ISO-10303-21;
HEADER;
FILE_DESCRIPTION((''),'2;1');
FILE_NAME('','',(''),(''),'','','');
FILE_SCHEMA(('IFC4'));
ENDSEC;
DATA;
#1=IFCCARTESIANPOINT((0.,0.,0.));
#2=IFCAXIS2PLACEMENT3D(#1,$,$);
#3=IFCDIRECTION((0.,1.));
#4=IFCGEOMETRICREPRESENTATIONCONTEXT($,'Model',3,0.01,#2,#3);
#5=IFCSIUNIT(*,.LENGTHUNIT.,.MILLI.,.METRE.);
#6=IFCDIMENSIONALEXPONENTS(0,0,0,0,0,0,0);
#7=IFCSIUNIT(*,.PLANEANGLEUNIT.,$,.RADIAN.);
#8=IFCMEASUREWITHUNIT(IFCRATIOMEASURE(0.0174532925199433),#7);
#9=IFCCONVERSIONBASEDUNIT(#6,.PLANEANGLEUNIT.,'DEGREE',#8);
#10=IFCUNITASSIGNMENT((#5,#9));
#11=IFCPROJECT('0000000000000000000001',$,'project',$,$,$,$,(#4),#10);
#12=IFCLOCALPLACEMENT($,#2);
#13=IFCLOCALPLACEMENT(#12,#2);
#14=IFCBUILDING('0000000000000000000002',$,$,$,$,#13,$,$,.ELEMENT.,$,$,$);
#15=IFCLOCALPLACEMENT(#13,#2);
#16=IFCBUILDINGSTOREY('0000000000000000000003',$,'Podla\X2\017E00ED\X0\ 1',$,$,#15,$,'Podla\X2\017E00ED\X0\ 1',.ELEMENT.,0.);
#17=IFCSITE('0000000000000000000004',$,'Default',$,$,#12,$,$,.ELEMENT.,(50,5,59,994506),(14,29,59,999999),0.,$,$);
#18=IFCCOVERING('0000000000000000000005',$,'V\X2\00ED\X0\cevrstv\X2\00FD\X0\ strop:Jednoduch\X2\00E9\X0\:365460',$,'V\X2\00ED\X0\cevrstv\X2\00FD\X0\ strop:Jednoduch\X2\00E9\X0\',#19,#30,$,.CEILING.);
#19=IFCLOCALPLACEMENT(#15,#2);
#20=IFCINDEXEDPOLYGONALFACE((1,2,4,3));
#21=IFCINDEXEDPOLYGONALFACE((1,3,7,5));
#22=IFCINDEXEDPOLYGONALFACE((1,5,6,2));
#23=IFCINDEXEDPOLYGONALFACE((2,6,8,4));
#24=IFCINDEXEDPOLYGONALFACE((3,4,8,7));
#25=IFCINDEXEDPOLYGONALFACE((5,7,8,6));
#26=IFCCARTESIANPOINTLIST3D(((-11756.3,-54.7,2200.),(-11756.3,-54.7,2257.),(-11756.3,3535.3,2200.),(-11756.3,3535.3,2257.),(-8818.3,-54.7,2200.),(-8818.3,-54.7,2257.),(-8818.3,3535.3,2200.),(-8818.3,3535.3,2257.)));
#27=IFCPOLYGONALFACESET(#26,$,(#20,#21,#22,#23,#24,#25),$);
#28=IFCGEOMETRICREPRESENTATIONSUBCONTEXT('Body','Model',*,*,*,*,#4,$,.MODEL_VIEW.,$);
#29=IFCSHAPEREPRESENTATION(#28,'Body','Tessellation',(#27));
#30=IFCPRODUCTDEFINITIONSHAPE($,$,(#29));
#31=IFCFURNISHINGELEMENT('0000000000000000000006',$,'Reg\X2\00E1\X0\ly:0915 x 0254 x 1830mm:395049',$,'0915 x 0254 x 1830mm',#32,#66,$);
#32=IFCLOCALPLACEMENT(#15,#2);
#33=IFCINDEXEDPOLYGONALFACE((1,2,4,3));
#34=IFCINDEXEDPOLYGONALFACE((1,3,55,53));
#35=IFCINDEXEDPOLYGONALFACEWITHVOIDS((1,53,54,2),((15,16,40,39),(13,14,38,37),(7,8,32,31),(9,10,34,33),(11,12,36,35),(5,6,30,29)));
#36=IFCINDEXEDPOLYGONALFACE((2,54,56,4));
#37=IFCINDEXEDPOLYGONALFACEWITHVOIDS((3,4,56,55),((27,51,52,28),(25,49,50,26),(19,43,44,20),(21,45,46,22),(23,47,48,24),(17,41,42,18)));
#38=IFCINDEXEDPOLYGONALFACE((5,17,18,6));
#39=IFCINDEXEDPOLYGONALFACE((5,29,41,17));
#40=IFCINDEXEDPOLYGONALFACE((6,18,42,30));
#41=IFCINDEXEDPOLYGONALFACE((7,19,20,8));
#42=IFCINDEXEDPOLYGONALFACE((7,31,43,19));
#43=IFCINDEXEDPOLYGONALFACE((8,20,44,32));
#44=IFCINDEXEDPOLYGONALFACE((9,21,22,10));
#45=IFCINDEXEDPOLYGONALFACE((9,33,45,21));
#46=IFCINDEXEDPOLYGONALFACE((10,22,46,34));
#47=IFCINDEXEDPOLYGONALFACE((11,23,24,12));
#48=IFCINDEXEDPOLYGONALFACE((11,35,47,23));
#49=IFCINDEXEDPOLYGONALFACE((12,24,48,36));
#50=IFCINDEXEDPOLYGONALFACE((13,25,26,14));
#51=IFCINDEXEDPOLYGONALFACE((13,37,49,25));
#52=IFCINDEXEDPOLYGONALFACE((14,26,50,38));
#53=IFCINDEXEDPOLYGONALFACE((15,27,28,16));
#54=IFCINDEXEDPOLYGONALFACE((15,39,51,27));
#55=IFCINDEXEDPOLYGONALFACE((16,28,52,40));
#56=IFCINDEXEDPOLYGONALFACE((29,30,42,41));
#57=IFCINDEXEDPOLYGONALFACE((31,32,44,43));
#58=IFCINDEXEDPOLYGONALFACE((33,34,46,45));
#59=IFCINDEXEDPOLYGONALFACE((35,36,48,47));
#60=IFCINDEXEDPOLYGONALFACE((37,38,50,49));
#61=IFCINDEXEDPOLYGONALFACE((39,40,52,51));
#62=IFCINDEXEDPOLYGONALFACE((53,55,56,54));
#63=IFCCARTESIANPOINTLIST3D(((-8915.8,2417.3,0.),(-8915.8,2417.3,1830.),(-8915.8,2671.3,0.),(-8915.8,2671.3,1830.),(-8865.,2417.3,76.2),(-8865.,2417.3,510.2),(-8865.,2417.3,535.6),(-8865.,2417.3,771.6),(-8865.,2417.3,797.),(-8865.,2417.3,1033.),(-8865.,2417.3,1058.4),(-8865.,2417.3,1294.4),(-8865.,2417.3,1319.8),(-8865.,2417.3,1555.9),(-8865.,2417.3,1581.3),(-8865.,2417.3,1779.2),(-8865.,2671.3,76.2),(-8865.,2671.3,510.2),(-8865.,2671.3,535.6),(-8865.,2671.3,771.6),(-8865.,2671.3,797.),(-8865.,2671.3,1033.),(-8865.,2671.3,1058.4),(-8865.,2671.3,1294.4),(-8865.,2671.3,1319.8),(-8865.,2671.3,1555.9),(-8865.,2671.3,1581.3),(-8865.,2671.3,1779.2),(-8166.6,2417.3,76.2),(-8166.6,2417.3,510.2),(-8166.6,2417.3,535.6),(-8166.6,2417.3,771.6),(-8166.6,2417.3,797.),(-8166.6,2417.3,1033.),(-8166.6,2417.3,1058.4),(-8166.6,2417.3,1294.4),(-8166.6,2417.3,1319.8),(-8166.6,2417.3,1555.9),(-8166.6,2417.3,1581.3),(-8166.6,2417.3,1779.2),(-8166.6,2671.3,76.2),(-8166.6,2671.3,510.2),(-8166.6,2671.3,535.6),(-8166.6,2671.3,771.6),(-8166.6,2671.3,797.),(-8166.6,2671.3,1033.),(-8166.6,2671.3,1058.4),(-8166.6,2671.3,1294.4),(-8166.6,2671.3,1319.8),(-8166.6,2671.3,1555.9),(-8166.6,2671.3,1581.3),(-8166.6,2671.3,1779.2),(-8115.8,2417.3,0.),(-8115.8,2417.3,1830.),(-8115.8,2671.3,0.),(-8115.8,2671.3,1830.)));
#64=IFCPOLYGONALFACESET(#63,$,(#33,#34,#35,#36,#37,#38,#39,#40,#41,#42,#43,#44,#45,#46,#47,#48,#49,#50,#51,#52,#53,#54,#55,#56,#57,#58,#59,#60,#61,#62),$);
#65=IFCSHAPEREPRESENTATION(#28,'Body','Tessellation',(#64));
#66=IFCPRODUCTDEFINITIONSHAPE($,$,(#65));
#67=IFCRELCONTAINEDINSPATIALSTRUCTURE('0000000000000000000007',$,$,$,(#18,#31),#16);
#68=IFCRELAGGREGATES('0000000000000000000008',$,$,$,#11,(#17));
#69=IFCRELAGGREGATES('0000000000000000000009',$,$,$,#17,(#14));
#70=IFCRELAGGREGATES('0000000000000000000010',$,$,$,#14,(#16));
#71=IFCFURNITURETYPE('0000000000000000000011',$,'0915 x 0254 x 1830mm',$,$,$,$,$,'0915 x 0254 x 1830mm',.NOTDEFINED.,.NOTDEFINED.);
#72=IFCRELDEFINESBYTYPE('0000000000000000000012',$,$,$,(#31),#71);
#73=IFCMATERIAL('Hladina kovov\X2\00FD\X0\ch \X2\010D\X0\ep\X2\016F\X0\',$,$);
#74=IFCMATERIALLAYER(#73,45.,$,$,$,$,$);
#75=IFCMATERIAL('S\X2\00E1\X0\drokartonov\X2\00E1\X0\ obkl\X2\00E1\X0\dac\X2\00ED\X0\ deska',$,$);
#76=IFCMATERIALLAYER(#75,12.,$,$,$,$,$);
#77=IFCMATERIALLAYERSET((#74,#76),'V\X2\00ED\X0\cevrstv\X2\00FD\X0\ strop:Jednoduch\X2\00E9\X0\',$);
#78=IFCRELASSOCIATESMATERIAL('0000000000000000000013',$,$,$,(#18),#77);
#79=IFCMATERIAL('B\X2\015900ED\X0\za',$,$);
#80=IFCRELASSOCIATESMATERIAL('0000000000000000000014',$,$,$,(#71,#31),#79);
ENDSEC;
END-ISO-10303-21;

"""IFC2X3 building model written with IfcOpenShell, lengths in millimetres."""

from ifc_helpers import new_model, entity, si_unit, converted_unit, direction, frame, frame_2d, origin, place, context, subcontext, project, spatial, polyline, rectangle, outline, extrude, source, transform, mapped, material, layer, layer_set, layer_usage, type_object, type_shapes, element, save


model = new_model("IFC2X3")

# Units and contexts
model_context = context("Model", 3, precision=0.01, world=origin(), true_north=direction((0.0, 1.0)))
body_context = subcontext(model_context, "Body", "Model", "MODEL_VIEW")
ifc_project = project(units=[si_unit("LENGTHUNIT", "METRE", prefix="MILLI"), converted_unit("PLANEANGLEUNIT", "DEGREE", entity("IfcRatioMeasure", 0.0174532925199433), si_unit("PLANEANGLEUNIT", "RADIAN"), dimensions=[0, 0, 0, 0, 0, 0, 0])], contexts=[model_context])

# Site, building, storey
site_placement = place(None, origin())
site = spatial("IfcSite", under=ifc_project, at=site_placement, Name="Default", CompositionType="ELEMENT", RefLatitude=(50, 5, 59, 994506), RefLongitude=(14, 29, 59, 999999), RefElevation=0.0)
building_placement = place(site_placement, origin())
building = spatial("IfcBuilding", under=site, at=building_placement, CompositionType="ELEMENT")
storey_placement = place(building_placement, origin())
storey = spatial("IfcBuildingStorey", under=building, at=storey_placement, Name="Podlaží 1", LongName="Podlaží 1", CompositionType="ELEMENT", Elevation=0.0)

# Shared definitions
ifc_material_1 = material(Name="Sádrokartonová obkládací deska")

# Covering
ifc_material_2 = material(Name="Hladina kovových čepů")
ifc_layer_1 = layer(ifc_material_2, 45.0)
ifc_layer_2 = layer(ifc_material_1, 12.0)
ifc_layer_set_1 = layer_set([ifc_layer_1, ifc_layer_2], Name="Vícevrstvý strop:Jednoduché")
ifc_layer_usage_1 = layer_usage(ifc_layer_set_1, "AXIS3", "NEGATIVE", 0.0)
covering_placement = place(storey_placement, origin())
element("IfcCovering", 1, at=covering_placement, inside=storey, material=ifc_layer_usage_1, Name="Vícevrstvý strop:Jednoduché:365460", ObjectType="Vícevrstvý strop:Jednoduché", PredefinedType="CEILING", context=body_context, shape_type="SweptSolid", body=[
    extrude(rectangle(XDim=2938.0, YDim=3590.0, at=frame_2d((0.0, 0.0), x_axis=(1.0, 0.0))), frame((-10287.3, 1740.3, 2200.0)), (0.0, 0.0, 1.0), 57.0),
])

# Furnishing element
ifc_material_3 = material(Name="Bříza")
furniture_type = type_object("IfcFurnitureType", Name="0915 x 0254 x 1830mm", ElementType="0915 x 0254 x 1830mm", AssemblyPlace="NOTDEFINED", material=ifc_material_3)
shared_shape_1 = source(origin(), body_context, "Body", "SweptSolid", [
    extrude(outline(polyline([(-400.0, -915.0), (400.0, -915.0), (400.0, 915.0), (-400.0, 915.0), (-400.0, -915.0)]), holes=[polyline([(-349.2, 864.2), (349.2, 864.2), (349.2, 666.3), (-349.2, 666.3), (-349.2, 864.2)]), polyline([(-349.2, -838.8), (-349.2, -404.8), (349.2, -404.8), (349.2, -838.8), (-349.2, -838.8)]), polyline([(349.2, 143.4), (-349.2, 143.4), (-349.2, 379.4), (349.2, 379.4), (349.2, 143.4)]), polyline([(-349.2, 640.9), (349.2, 640.9), (349.2, 404.8), (-349.2, 404.8), (-349.2, 640.9)]), polyline([(-349.2, 118.0), (349.2, 118.0), (349.2, -118.0), (-349.2, -118.0), (-349.2, 118.0)]), polyline([(-349.2, -143.4), (349.2, -143.4), (349.2, -379.4), (-349.2, -379.4), (-349.2, -143.4)])]), frame((0.0, -431.8, 915.0), z_axis=(0.0, 1.0, 0.0), x_axis=(-1.0, 0.0, 0.0)), (0.0, 0.0, 1.0), 254.0),
])
type_shapes(furniture_type, [shared_shape_1])
furnishing_placement = place(storey_placement, frame((-8515.8, 2849.1, 0.0)))
element("IfcFurnishingElement", 2, at=furnishing_placement, inside=storey, type_object=furniture_type, material=ifc_material_3, Name="Regály:0915 x 0254 x 1830mm:395049", ObjectType="0915 x 0254 x 1830mm", context=body_context, shape_type="MappedRepresentation", body=[
    mapped(shared_shape_1, transform((0.0, 0.0, 0.0), scale=1.0)),
])

save(model, "model.ifc")
